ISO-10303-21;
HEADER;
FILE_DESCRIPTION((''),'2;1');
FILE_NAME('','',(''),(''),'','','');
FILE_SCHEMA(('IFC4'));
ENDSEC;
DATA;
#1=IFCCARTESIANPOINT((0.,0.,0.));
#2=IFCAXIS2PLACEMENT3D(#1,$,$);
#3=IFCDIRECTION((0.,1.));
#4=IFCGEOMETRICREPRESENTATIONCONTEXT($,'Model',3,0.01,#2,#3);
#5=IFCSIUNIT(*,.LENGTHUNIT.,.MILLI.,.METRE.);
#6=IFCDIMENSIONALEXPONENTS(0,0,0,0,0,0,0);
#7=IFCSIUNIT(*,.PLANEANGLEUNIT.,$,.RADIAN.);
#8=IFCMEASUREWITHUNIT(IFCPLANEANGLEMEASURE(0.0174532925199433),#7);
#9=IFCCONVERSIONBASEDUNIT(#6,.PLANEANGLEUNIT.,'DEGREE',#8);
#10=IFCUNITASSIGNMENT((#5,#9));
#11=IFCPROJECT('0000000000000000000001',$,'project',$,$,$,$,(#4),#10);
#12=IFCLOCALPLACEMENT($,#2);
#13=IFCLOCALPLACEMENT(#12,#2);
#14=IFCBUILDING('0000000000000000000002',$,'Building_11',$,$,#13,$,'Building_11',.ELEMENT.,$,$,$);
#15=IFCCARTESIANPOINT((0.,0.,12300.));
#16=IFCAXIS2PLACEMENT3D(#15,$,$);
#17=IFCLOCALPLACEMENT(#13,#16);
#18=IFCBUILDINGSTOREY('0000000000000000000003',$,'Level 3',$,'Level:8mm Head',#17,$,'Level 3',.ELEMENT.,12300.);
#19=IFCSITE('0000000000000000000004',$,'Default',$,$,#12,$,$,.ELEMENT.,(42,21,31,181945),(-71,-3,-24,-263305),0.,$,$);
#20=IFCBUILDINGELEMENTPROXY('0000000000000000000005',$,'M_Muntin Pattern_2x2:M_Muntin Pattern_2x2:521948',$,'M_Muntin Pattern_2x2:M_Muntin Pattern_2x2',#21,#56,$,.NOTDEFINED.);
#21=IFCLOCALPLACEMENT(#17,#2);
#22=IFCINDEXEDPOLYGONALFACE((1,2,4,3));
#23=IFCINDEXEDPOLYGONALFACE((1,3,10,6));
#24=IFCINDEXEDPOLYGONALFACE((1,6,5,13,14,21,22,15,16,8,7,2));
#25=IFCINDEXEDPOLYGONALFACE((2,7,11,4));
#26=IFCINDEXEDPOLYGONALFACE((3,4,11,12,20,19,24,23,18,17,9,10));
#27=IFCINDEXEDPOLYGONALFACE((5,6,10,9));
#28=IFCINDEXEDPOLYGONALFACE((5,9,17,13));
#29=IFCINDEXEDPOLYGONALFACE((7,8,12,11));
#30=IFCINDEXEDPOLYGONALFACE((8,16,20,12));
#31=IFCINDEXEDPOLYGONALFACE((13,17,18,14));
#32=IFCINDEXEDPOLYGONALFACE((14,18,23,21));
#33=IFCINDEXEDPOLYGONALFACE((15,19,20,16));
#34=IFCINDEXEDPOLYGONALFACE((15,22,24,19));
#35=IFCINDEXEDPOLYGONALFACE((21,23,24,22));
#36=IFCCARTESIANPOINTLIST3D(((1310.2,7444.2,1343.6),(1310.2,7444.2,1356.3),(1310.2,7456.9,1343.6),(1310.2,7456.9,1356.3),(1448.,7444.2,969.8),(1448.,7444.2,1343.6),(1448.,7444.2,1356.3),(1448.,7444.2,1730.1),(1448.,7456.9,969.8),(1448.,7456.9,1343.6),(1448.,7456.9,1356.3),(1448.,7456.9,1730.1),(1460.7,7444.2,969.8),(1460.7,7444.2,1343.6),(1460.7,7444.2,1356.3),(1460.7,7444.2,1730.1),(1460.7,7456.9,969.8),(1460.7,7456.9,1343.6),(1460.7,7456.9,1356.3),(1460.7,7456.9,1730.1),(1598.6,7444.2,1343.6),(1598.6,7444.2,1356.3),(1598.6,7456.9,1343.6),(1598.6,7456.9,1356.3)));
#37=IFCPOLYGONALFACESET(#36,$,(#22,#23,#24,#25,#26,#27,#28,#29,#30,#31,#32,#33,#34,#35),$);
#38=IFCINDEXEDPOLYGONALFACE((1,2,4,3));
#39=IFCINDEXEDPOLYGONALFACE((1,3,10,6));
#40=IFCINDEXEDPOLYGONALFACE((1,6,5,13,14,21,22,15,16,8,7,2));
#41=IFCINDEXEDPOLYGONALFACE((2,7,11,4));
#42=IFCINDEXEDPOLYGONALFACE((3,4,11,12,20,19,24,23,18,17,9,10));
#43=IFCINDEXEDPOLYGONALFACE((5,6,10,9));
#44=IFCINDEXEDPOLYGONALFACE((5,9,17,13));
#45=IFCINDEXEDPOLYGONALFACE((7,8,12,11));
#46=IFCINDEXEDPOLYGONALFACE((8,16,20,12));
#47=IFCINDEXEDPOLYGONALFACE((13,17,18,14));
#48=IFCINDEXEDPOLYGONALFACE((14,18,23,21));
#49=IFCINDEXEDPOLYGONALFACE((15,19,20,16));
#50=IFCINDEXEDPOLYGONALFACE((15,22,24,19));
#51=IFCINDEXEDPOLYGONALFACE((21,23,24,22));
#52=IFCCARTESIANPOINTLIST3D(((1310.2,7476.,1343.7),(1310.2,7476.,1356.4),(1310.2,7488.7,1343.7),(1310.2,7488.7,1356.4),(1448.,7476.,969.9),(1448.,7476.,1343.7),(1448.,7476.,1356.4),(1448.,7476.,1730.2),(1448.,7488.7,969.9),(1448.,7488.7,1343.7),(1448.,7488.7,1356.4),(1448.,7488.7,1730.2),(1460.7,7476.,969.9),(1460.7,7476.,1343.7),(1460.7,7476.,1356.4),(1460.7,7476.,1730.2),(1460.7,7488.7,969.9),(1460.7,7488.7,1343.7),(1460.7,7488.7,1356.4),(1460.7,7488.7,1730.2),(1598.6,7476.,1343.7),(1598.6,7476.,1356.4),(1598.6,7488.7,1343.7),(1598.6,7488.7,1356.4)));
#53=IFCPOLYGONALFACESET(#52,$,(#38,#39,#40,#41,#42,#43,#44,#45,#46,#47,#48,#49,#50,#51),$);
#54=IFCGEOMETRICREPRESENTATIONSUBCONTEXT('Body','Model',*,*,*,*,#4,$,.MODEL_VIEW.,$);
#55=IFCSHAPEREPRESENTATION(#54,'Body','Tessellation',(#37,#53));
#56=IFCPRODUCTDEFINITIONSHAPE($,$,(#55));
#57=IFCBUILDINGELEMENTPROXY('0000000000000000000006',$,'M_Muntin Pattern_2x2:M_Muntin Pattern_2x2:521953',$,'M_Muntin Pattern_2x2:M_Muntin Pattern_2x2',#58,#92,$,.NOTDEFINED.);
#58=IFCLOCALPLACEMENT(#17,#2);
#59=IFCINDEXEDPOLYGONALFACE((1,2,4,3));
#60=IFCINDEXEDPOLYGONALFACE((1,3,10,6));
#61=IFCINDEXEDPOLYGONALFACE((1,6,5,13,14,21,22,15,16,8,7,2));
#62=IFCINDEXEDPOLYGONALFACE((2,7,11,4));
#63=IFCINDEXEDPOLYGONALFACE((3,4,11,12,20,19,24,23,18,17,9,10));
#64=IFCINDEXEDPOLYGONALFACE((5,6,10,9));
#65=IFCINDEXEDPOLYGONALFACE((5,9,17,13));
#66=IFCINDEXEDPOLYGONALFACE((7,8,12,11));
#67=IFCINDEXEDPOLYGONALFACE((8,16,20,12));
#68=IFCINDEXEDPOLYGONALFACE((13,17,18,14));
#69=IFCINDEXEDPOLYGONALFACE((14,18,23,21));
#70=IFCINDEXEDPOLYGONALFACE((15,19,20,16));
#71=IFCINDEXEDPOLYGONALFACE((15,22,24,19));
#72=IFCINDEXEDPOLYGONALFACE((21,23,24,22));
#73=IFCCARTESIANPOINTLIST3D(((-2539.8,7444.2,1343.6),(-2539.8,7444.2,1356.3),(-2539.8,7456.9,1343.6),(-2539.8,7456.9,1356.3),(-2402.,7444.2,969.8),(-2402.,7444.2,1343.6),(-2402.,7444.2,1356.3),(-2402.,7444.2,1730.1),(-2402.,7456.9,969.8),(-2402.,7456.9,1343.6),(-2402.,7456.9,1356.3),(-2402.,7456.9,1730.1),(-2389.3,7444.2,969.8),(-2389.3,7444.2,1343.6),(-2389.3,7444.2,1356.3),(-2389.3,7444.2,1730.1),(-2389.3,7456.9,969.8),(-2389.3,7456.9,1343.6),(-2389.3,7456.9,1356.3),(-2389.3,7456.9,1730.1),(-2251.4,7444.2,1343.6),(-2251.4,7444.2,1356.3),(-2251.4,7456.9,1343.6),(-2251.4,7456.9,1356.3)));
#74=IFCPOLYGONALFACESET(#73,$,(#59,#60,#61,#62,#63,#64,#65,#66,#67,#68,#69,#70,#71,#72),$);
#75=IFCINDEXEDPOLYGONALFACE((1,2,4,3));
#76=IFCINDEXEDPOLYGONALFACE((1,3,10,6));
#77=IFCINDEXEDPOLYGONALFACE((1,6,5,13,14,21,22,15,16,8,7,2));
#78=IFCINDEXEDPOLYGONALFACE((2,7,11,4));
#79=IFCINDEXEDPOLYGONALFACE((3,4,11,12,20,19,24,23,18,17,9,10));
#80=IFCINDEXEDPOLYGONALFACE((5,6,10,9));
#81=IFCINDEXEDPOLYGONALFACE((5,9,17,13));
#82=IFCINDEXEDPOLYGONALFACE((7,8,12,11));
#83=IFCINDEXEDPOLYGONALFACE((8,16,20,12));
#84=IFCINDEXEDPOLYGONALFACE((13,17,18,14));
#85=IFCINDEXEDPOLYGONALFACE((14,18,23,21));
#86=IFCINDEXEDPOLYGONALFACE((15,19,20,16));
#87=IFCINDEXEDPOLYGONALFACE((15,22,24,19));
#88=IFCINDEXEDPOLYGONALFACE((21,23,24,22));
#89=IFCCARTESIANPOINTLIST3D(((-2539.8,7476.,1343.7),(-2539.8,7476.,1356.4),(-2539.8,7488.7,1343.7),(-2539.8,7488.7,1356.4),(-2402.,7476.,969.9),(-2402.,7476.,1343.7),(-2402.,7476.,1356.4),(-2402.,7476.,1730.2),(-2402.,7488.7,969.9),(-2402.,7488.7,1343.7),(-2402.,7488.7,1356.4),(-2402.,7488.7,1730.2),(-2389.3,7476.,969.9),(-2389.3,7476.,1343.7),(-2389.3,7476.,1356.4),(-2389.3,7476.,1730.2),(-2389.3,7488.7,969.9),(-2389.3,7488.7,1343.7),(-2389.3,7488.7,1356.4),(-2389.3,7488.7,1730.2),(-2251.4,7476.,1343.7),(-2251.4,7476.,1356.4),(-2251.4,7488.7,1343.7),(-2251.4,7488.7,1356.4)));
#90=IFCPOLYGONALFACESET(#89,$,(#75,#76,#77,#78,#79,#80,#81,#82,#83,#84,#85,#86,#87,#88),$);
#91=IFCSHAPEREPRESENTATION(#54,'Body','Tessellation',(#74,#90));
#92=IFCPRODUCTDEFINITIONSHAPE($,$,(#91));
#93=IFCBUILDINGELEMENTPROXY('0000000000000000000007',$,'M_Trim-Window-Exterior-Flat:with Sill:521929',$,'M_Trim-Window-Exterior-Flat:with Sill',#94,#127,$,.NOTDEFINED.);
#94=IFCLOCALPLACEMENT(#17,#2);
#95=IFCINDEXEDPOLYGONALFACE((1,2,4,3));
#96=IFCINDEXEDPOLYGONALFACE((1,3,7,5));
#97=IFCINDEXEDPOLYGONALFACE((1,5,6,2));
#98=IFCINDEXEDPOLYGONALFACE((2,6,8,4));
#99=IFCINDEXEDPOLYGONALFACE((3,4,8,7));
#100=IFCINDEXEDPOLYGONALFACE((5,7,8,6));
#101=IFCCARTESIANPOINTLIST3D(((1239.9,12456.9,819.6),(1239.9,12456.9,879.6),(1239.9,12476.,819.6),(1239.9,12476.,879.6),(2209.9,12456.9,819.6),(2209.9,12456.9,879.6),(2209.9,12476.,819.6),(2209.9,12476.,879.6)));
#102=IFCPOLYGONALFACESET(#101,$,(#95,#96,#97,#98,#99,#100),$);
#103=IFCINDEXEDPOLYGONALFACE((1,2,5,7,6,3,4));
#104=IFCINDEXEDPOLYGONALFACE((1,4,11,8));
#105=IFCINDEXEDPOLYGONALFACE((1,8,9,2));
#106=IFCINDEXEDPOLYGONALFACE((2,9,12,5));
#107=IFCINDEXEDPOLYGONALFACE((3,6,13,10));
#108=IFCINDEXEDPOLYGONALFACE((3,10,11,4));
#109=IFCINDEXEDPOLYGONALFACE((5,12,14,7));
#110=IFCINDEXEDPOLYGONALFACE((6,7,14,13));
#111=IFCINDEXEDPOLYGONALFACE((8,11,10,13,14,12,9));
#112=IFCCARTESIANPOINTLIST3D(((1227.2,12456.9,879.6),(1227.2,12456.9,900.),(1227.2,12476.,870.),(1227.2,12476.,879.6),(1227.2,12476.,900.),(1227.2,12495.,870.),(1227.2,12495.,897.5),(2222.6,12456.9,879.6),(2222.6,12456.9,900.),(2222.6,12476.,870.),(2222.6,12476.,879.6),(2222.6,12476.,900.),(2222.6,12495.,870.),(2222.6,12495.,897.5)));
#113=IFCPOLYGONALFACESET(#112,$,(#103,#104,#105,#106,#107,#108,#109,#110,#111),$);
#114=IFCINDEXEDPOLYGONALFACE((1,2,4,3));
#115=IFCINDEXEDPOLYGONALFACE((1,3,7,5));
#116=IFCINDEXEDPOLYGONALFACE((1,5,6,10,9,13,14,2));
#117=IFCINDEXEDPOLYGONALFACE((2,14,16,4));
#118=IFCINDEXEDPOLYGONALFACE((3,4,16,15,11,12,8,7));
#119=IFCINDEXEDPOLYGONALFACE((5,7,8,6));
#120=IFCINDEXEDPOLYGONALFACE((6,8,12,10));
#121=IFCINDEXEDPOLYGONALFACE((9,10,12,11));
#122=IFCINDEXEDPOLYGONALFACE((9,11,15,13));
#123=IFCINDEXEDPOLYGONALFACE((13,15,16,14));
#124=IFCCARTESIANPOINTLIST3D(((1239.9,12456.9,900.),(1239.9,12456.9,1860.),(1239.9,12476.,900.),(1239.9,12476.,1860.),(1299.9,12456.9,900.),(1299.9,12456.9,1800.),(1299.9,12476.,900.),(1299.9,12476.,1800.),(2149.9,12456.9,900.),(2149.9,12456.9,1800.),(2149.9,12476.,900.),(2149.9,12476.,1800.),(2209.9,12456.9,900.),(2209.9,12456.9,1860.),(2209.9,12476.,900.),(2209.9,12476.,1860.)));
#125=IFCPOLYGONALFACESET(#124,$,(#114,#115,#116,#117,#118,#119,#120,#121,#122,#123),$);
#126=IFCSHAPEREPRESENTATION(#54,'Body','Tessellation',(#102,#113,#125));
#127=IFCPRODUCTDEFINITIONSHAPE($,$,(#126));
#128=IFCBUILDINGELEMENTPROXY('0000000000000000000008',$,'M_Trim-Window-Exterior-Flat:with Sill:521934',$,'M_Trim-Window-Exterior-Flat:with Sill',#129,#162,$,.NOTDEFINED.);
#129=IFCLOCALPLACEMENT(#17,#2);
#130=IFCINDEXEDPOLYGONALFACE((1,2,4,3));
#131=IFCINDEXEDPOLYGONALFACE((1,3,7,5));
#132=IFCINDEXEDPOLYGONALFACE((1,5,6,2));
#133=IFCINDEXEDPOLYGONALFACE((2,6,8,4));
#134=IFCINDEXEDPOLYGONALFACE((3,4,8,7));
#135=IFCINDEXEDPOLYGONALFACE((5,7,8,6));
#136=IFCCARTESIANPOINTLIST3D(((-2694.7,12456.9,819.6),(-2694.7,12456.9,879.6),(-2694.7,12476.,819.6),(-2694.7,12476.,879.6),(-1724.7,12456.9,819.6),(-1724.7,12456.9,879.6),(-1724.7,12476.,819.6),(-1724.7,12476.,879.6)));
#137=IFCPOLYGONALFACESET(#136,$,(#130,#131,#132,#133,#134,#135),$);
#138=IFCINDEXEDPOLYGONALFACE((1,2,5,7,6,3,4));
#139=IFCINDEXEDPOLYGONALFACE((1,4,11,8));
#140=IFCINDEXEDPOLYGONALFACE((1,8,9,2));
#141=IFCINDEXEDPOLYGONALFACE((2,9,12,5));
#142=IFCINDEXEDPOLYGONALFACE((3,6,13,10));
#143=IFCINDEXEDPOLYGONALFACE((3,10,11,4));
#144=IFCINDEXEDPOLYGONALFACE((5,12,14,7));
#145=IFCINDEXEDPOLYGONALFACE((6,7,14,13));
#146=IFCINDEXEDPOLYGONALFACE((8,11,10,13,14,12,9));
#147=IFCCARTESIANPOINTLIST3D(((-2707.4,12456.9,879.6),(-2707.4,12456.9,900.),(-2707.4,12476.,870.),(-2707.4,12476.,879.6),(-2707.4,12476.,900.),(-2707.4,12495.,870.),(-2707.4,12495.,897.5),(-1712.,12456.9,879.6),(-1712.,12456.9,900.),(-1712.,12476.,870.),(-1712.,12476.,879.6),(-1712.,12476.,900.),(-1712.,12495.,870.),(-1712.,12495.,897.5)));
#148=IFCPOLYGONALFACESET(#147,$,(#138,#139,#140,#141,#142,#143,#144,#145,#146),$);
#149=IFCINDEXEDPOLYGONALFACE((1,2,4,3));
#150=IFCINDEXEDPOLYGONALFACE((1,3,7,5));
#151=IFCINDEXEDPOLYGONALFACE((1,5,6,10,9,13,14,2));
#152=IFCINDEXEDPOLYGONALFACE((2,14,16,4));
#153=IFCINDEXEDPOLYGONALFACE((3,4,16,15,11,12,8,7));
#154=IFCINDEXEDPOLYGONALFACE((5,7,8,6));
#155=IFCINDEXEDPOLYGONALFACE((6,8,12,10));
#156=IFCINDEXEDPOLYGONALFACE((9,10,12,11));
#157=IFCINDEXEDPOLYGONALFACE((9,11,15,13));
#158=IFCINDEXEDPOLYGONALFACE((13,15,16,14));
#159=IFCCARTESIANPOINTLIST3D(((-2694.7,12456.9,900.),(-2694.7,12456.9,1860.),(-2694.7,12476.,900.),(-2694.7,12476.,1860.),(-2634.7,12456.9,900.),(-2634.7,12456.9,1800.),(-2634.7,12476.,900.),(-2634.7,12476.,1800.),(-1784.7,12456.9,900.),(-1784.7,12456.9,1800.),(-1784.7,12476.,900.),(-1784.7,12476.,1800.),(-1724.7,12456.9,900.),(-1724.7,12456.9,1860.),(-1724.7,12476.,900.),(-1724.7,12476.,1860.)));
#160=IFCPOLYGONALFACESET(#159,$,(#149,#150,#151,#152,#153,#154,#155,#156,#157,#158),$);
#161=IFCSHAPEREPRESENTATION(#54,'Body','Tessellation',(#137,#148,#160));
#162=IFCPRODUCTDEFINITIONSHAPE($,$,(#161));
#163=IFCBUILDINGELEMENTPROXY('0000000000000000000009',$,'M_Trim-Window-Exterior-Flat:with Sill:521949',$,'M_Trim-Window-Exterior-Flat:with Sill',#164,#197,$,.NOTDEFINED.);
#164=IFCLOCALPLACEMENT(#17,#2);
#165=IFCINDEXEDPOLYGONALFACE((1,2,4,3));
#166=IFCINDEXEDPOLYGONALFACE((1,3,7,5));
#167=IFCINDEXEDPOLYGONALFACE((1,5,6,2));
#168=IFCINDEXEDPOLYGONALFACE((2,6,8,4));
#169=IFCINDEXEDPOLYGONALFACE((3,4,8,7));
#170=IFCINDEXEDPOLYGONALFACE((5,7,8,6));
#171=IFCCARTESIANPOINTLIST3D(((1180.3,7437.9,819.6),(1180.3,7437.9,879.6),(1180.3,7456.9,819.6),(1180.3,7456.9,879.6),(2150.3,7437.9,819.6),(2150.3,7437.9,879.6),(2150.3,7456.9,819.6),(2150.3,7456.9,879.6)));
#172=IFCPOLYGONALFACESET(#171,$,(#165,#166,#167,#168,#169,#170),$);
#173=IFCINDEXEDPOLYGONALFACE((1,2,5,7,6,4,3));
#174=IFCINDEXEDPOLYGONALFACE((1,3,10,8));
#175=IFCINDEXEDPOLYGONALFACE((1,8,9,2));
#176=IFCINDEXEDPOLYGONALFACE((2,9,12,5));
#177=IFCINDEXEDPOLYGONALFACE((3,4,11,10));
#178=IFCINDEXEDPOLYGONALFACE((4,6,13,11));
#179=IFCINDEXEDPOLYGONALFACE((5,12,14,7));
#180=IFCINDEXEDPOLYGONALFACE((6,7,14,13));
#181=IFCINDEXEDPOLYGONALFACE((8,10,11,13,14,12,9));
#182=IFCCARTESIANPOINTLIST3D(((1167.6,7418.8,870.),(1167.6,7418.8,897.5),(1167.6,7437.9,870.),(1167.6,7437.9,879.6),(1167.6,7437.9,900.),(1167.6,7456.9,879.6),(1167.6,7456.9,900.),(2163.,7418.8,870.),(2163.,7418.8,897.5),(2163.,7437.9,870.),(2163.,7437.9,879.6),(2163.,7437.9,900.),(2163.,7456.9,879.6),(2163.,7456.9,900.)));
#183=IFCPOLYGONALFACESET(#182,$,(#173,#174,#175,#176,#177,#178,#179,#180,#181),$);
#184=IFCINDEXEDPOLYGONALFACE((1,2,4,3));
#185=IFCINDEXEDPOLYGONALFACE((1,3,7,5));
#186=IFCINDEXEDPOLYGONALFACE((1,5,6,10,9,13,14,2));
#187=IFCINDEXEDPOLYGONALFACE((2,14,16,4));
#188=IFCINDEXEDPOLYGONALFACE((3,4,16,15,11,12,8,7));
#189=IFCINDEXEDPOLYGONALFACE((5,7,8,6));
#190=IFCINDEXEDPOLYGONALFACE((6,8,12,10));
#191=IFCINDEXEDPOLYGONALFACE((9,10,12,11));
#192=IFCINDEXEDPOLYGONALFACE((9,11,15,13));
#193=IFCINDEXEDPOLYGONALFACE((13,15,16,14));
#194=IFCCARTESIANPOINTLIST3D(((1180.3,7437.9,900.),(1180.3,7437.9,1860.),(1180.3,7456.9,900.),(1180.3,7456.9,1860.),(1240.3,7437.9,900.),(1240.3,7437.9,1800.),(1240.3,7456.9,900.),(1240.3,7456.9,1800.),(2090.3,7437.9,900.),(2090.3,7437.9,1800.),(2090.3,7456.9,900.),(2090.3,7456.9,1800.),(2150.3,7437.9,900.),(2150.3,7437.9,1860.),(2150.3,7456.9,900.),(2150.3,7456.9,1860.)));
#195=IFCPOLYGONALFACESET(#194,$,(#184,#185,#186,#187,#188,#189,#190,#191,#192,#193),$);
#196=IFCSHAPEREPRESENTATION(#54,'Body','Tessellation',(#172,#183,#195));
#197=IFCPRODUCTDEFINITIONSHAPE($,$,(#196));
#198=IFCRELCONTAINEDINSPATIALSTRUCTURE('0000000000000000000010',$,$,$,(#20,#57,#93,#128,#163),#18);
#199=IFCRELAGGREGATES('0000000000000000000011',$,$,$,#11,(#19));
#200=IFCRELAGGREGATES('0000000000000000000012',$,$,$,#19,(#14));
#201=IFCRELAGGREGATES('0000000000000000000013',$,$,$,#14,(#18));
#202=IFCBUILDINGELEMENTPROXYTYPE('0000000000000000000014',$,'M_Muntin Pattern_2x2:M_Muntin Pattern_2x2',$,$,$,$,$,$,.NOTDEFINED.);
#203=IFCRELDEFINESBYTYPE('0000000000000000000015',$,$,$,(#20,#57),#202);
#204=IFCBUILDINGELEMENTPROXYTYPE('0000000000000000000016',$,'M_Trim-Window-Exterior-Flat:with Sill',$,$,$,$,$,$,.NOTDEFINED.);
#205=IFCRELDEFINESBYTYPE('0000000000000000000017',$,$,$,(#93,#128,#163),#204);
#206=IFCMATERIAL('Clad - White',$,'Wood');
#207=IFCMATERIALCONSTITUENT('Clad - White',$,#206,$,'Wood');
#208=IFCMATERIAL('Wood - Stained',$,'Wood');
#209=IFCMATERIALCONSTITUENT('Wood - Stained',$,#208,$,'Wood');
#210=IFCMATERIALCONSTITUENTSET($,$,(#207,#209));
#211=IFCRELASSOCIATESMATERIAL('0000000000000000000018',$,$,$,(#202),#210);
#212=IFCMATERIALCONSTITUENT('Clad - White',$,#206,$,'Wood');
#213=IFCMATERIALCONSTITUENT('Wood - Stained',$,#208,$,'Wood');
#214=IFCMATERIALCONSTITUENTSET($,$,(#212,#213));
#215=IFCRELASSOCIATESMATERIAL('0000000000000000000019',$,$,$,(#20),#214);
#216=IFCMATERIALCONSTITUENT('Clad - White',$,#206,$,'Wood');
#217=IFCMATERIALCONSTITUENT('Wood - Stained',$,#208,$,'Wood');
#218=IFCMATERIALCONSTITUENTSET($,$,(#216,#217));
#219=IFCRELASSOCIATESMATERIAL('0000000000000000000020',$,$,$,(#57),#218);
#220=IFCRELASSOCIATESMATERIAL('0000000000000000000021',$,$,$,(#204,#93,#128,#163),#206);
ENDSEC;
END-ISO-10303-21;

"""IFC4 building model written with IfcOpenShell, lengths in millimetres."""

from ifc_helpers import new_model, entity, si_unit, converted_unit, direction, frame, origin, place, context, subcontext, project, spatial, indexed_curve, outline, extrude, source, transform, mapped, material, constituent, constituent_set, type_object, type_shapes, element, save


model = new_model("IFC4")

# Units and contexts
model_context = context("Model", 3, precision=0.01, world=origin(), true_north=direction((0.0, 1.0)))
body_context = subcontext(model_context, "Body", "Model", "MODEL_VIEW")
ifc_project = project(units=[si_unit("LENGTHUNIT", "METRE", prefix="MILLI"), converted_unit("PLANEANGLEUNIT", "DEGREE", entity("IfcPlaneAngleMeasure", 0.0174532925199433), si_unit("PLANEANGLEUNIT", "RADIAN"), dimensions=[0, 0, 0, 0, 0, 0, 0])], contexts=[model_context])

# Site, building, storey
site_placement = place(None, origin())
site = spatial("IfcSite", under=ifc_project, at=site_placement, Name="Default", CompositionType="ELEMENT", RefLatitude=(42, 21, 31, 181945), RefLongitude=(-71, -3, -24, -263305), RefElevation=0.0)
building_placement = place(site_placement, origin())
building = spatial("IfcBuilding", under=site, at=building_placement, Name="Building_11", LongName="Building_11", CompositionType="ELEMENT")
storey_placement = place(building_placement, frame((0.0, 0.0, 12300.0)))
storey = spatial("IfcBuildingStorey", under=building, at=storey_placement, Name="Level 3", ObjectType="Level:8mm Head", LongName="Level 3", CompositionType="ELEMENT", Elevation=12300.0)

# Building element proxies
ifc_material_1 = material(Name="Clad - White", Category="Wood")
ifc_material_2 = material(Name="Wood - Stained", Category="Wood")
ifc_constituent_1 = constituent(ifc_material_1, Name="Clad - White", Category="Wood")
ifc_constituent_2 = constituent(ifc_material_2, Name="Wood - Stained", Category="Wood")
ifc_constituent_set_1 = constituent_set(constituents=[ifc_constituent_1, ifc_constituent_2])
building_element_proxy_type_1 = type_object("IfcBuildingElementProxyType", Name="M_Muntin Pattern_2x2:M_Muntin Pattern_2x2", PredefinedType="NOTDEFINED", material=ifc_constituent_set_1)
shared_shape_1 = source(origin(), body_context, "Body", "SweptSolid", [
    extrude(outline(indexed_curve([(6.4, -6.4), (380.1, -6.4), (380.1, 6.3), (6.4, 6.3), (6.4, 144.2), (-6.3, 144.2), (-6.3, 6.3), (-380.2, 6.3), (-380.2, -6.4), (-6.3, -6.4), (-6.3, -144.2), (6.4, -144.2), (6.4, -6.4)], self_intersect=False)), frame((0.0, -22.2, 380.1), z_axis=(0.0, 1.0, 0.0), x_axis=(0.0, 0.0, 1.0)), (0.0, 0.0, 1.0), 12.7),
    extrude(outline(indexed_curve([(6.4, -6.4), (380.2, -6.4), (380.2, 6.3), (6.4, 6.3), (6.4, 144.2), (-6.3, 144.2), (-6.3, 6.3), (-380.2, 6.3), (-380.2, -6.4), (-6.3, -6.4), (-6.3, -144.2), (6.4, -144.2), (6.4, -6.4)], self_intersect=False)), frame((0.0, 9.5, 380.2), z_axis=(0.0, 1.0, 0.0), x_axis=(0.0, 0.0, 1.0)), (0.0, 0.0, 1.0), 12.7),
])
type_shapes(building_element_proxy_type_1, [shared_shape_1])
ifc_constituent_3 = constituent(ifc_material_1, Name="Clad - White", Category="Wood")
ifc_constituent_4 = constituent(ifc_material_2, Name="Wood - Stained", Category="Wood")
ifc_constituent_set_2 = constituent_set(constituents=[ifc_constituent_3, ifc_constituent_4])
proxy_1_placement = place(storey_placement, frame((1454.4, 7466.4, 969.9)))
element("IfcBuildingElementProxy", 1, at=proxy_1_placement, inside=storey, type_object=building_element_proxy_type_1, material=ifc_constituent_set_2, Name="M_Muntin Pattern_2x2:M_Muntin Pattern_2x2:521948", ObjectType="M_Muntin Pattern_2x2:M_Muntin Pattern_2x2", PredefinedType="NOTDEFINED", context=body_context, shape_type="MappedRepresentation", body=[
    mapped(shared_shape_1, transform((0.0, 0.0, 0.0), scale=1.0)),
])
ifc_constituent_5 = constituent(ifc_material_1, Name="Clad - White", Category="Wood")
ifc_constituent_6 = constituent(ifc_material_2, Name="Wood - Stained", Category="Wood")
ifc_constituent_set_3 = constituent_set(constituents=[ifc_constituent_5, ifc_constituent_6])
proxy_2_placement = place(storey_placement, frame((-2395.6, 7466.4, 969.9)))
element("IfcBuildingElementProxy", 2, at=proxy_2_placement, inside=storey, type_object=building_element_proxy_type_1, material=ifc_constituent_set_3, Name="M_Muntin Pattern_2x2:M_Muntin Pattern_2x2:521953", ObjectType="M_Muntin Pattern_2x2:M_Muntin Pattern_2x2", PredefinedType="NOTDEFINED", context=body_context, shape_type="MappedRepresentation", body=[
    mapped(shared_shape_1, transform((0.0, 0.0, 0.0), scale=1.0)),
])
building_element_proxy_type_2 = type_object("IfcBuildingElementProxyType", Name="M_Trim-Window-Exterior-Flat:with Sill", PredefinedType="NOTDEFINED", material=ifc_material_1)
shared_shape_2 = source(origin(), body_context, "Body", "SweptSolid", [
    extrude(outline(indexed_curve([(-485.0, -30.0), (485.0, -30.0), (485.0, 30.0), (-485.0, 30.0), (-485.0, -30.0)], self_intersect=False)), frame((0.0, -950.4, 0.0), z_axis=(0.0, 0.0, 1.0), x_axis=(-1.0, 0.0, 0.0)), (0.0, 0.0, 1.0), 19.1),
    extrude(outline(indexed_curve([(-19.0, -15.2), (0.0, -15.2), (0.0, -5.7), (19.0, -5.7), (19.0, 14.8), (0.0, 14.8), (-19.0, 12.3), (-19.0, -15.2)], self_intersect=False)), frame((-497.7, -914.8, 19.0), z_axis=(1.0, 0.0, 0.0), x_axis=(0.0, 0.0, -1.0)), (0.0, 0.0, 1.0), 995.4),
    extrude(outline(indexed_curve([(-495.0, -485.0), (465.0, -485.0), (465.0, -425.0), (-435.0, -425.0), (-435.0, 425.0), (465.0, 425.0), (465.0, 485.0), (-495.0, 485.0), (-495.0, -485.0)], self_intersect=False)), frame((0.0, -435.0, 0.0), z_axis=(0.0, 0.0, 1.0), x_axis=(0.0, -1.0, 0.0)), (0.0, 0.0, 1.0), 19.1),
])
type_shapes(building_element_proxy_type_2, [shared_shape_2])
for number, where, z_axis, x_axis, name in (
    (3, (1724.9, 12456.9, 1800.0), (0.0, 1.0, 0.0), (-1.0, 0.0, 0.0), "M_Trim-Window-Exterior-Flat:with Sill:521929"),
    (4, (-2209.7, 12456.9, 1800.0), (0.0, 1.0, 0.0), (-1.0, 0.0, 0.0), "M_Trim-Window-Exterior-Flat:with Sill:521934"),
    (5, (1665.3, 7456.9, 1800.0), (0.0, -1.0, 0.0), (1.0, 0.0, 0.0), "M_Trim-Window-Exterior-Flat:with Sill:521949"),
):
    element("IfcBuildingElementProxy", number, at=place(storey_placement, frame(where, z_axis=z_axis, x_axis=x_axis)), inside=storey, type_object=building_element_proxy_type_2, material=ifc_material_1, Name=name, ObjectType="M_Trim-Window-Exterior-Flat:with Sill", PredefinedType="NOTDEFINED", context=body_context, shape_type="MappedRepresentation", body=[
        mapped(shared_shape_2, transform((0.0, 0.0, 0.0), scale=1.0)),
    ])

save(model, "model.ifc")
